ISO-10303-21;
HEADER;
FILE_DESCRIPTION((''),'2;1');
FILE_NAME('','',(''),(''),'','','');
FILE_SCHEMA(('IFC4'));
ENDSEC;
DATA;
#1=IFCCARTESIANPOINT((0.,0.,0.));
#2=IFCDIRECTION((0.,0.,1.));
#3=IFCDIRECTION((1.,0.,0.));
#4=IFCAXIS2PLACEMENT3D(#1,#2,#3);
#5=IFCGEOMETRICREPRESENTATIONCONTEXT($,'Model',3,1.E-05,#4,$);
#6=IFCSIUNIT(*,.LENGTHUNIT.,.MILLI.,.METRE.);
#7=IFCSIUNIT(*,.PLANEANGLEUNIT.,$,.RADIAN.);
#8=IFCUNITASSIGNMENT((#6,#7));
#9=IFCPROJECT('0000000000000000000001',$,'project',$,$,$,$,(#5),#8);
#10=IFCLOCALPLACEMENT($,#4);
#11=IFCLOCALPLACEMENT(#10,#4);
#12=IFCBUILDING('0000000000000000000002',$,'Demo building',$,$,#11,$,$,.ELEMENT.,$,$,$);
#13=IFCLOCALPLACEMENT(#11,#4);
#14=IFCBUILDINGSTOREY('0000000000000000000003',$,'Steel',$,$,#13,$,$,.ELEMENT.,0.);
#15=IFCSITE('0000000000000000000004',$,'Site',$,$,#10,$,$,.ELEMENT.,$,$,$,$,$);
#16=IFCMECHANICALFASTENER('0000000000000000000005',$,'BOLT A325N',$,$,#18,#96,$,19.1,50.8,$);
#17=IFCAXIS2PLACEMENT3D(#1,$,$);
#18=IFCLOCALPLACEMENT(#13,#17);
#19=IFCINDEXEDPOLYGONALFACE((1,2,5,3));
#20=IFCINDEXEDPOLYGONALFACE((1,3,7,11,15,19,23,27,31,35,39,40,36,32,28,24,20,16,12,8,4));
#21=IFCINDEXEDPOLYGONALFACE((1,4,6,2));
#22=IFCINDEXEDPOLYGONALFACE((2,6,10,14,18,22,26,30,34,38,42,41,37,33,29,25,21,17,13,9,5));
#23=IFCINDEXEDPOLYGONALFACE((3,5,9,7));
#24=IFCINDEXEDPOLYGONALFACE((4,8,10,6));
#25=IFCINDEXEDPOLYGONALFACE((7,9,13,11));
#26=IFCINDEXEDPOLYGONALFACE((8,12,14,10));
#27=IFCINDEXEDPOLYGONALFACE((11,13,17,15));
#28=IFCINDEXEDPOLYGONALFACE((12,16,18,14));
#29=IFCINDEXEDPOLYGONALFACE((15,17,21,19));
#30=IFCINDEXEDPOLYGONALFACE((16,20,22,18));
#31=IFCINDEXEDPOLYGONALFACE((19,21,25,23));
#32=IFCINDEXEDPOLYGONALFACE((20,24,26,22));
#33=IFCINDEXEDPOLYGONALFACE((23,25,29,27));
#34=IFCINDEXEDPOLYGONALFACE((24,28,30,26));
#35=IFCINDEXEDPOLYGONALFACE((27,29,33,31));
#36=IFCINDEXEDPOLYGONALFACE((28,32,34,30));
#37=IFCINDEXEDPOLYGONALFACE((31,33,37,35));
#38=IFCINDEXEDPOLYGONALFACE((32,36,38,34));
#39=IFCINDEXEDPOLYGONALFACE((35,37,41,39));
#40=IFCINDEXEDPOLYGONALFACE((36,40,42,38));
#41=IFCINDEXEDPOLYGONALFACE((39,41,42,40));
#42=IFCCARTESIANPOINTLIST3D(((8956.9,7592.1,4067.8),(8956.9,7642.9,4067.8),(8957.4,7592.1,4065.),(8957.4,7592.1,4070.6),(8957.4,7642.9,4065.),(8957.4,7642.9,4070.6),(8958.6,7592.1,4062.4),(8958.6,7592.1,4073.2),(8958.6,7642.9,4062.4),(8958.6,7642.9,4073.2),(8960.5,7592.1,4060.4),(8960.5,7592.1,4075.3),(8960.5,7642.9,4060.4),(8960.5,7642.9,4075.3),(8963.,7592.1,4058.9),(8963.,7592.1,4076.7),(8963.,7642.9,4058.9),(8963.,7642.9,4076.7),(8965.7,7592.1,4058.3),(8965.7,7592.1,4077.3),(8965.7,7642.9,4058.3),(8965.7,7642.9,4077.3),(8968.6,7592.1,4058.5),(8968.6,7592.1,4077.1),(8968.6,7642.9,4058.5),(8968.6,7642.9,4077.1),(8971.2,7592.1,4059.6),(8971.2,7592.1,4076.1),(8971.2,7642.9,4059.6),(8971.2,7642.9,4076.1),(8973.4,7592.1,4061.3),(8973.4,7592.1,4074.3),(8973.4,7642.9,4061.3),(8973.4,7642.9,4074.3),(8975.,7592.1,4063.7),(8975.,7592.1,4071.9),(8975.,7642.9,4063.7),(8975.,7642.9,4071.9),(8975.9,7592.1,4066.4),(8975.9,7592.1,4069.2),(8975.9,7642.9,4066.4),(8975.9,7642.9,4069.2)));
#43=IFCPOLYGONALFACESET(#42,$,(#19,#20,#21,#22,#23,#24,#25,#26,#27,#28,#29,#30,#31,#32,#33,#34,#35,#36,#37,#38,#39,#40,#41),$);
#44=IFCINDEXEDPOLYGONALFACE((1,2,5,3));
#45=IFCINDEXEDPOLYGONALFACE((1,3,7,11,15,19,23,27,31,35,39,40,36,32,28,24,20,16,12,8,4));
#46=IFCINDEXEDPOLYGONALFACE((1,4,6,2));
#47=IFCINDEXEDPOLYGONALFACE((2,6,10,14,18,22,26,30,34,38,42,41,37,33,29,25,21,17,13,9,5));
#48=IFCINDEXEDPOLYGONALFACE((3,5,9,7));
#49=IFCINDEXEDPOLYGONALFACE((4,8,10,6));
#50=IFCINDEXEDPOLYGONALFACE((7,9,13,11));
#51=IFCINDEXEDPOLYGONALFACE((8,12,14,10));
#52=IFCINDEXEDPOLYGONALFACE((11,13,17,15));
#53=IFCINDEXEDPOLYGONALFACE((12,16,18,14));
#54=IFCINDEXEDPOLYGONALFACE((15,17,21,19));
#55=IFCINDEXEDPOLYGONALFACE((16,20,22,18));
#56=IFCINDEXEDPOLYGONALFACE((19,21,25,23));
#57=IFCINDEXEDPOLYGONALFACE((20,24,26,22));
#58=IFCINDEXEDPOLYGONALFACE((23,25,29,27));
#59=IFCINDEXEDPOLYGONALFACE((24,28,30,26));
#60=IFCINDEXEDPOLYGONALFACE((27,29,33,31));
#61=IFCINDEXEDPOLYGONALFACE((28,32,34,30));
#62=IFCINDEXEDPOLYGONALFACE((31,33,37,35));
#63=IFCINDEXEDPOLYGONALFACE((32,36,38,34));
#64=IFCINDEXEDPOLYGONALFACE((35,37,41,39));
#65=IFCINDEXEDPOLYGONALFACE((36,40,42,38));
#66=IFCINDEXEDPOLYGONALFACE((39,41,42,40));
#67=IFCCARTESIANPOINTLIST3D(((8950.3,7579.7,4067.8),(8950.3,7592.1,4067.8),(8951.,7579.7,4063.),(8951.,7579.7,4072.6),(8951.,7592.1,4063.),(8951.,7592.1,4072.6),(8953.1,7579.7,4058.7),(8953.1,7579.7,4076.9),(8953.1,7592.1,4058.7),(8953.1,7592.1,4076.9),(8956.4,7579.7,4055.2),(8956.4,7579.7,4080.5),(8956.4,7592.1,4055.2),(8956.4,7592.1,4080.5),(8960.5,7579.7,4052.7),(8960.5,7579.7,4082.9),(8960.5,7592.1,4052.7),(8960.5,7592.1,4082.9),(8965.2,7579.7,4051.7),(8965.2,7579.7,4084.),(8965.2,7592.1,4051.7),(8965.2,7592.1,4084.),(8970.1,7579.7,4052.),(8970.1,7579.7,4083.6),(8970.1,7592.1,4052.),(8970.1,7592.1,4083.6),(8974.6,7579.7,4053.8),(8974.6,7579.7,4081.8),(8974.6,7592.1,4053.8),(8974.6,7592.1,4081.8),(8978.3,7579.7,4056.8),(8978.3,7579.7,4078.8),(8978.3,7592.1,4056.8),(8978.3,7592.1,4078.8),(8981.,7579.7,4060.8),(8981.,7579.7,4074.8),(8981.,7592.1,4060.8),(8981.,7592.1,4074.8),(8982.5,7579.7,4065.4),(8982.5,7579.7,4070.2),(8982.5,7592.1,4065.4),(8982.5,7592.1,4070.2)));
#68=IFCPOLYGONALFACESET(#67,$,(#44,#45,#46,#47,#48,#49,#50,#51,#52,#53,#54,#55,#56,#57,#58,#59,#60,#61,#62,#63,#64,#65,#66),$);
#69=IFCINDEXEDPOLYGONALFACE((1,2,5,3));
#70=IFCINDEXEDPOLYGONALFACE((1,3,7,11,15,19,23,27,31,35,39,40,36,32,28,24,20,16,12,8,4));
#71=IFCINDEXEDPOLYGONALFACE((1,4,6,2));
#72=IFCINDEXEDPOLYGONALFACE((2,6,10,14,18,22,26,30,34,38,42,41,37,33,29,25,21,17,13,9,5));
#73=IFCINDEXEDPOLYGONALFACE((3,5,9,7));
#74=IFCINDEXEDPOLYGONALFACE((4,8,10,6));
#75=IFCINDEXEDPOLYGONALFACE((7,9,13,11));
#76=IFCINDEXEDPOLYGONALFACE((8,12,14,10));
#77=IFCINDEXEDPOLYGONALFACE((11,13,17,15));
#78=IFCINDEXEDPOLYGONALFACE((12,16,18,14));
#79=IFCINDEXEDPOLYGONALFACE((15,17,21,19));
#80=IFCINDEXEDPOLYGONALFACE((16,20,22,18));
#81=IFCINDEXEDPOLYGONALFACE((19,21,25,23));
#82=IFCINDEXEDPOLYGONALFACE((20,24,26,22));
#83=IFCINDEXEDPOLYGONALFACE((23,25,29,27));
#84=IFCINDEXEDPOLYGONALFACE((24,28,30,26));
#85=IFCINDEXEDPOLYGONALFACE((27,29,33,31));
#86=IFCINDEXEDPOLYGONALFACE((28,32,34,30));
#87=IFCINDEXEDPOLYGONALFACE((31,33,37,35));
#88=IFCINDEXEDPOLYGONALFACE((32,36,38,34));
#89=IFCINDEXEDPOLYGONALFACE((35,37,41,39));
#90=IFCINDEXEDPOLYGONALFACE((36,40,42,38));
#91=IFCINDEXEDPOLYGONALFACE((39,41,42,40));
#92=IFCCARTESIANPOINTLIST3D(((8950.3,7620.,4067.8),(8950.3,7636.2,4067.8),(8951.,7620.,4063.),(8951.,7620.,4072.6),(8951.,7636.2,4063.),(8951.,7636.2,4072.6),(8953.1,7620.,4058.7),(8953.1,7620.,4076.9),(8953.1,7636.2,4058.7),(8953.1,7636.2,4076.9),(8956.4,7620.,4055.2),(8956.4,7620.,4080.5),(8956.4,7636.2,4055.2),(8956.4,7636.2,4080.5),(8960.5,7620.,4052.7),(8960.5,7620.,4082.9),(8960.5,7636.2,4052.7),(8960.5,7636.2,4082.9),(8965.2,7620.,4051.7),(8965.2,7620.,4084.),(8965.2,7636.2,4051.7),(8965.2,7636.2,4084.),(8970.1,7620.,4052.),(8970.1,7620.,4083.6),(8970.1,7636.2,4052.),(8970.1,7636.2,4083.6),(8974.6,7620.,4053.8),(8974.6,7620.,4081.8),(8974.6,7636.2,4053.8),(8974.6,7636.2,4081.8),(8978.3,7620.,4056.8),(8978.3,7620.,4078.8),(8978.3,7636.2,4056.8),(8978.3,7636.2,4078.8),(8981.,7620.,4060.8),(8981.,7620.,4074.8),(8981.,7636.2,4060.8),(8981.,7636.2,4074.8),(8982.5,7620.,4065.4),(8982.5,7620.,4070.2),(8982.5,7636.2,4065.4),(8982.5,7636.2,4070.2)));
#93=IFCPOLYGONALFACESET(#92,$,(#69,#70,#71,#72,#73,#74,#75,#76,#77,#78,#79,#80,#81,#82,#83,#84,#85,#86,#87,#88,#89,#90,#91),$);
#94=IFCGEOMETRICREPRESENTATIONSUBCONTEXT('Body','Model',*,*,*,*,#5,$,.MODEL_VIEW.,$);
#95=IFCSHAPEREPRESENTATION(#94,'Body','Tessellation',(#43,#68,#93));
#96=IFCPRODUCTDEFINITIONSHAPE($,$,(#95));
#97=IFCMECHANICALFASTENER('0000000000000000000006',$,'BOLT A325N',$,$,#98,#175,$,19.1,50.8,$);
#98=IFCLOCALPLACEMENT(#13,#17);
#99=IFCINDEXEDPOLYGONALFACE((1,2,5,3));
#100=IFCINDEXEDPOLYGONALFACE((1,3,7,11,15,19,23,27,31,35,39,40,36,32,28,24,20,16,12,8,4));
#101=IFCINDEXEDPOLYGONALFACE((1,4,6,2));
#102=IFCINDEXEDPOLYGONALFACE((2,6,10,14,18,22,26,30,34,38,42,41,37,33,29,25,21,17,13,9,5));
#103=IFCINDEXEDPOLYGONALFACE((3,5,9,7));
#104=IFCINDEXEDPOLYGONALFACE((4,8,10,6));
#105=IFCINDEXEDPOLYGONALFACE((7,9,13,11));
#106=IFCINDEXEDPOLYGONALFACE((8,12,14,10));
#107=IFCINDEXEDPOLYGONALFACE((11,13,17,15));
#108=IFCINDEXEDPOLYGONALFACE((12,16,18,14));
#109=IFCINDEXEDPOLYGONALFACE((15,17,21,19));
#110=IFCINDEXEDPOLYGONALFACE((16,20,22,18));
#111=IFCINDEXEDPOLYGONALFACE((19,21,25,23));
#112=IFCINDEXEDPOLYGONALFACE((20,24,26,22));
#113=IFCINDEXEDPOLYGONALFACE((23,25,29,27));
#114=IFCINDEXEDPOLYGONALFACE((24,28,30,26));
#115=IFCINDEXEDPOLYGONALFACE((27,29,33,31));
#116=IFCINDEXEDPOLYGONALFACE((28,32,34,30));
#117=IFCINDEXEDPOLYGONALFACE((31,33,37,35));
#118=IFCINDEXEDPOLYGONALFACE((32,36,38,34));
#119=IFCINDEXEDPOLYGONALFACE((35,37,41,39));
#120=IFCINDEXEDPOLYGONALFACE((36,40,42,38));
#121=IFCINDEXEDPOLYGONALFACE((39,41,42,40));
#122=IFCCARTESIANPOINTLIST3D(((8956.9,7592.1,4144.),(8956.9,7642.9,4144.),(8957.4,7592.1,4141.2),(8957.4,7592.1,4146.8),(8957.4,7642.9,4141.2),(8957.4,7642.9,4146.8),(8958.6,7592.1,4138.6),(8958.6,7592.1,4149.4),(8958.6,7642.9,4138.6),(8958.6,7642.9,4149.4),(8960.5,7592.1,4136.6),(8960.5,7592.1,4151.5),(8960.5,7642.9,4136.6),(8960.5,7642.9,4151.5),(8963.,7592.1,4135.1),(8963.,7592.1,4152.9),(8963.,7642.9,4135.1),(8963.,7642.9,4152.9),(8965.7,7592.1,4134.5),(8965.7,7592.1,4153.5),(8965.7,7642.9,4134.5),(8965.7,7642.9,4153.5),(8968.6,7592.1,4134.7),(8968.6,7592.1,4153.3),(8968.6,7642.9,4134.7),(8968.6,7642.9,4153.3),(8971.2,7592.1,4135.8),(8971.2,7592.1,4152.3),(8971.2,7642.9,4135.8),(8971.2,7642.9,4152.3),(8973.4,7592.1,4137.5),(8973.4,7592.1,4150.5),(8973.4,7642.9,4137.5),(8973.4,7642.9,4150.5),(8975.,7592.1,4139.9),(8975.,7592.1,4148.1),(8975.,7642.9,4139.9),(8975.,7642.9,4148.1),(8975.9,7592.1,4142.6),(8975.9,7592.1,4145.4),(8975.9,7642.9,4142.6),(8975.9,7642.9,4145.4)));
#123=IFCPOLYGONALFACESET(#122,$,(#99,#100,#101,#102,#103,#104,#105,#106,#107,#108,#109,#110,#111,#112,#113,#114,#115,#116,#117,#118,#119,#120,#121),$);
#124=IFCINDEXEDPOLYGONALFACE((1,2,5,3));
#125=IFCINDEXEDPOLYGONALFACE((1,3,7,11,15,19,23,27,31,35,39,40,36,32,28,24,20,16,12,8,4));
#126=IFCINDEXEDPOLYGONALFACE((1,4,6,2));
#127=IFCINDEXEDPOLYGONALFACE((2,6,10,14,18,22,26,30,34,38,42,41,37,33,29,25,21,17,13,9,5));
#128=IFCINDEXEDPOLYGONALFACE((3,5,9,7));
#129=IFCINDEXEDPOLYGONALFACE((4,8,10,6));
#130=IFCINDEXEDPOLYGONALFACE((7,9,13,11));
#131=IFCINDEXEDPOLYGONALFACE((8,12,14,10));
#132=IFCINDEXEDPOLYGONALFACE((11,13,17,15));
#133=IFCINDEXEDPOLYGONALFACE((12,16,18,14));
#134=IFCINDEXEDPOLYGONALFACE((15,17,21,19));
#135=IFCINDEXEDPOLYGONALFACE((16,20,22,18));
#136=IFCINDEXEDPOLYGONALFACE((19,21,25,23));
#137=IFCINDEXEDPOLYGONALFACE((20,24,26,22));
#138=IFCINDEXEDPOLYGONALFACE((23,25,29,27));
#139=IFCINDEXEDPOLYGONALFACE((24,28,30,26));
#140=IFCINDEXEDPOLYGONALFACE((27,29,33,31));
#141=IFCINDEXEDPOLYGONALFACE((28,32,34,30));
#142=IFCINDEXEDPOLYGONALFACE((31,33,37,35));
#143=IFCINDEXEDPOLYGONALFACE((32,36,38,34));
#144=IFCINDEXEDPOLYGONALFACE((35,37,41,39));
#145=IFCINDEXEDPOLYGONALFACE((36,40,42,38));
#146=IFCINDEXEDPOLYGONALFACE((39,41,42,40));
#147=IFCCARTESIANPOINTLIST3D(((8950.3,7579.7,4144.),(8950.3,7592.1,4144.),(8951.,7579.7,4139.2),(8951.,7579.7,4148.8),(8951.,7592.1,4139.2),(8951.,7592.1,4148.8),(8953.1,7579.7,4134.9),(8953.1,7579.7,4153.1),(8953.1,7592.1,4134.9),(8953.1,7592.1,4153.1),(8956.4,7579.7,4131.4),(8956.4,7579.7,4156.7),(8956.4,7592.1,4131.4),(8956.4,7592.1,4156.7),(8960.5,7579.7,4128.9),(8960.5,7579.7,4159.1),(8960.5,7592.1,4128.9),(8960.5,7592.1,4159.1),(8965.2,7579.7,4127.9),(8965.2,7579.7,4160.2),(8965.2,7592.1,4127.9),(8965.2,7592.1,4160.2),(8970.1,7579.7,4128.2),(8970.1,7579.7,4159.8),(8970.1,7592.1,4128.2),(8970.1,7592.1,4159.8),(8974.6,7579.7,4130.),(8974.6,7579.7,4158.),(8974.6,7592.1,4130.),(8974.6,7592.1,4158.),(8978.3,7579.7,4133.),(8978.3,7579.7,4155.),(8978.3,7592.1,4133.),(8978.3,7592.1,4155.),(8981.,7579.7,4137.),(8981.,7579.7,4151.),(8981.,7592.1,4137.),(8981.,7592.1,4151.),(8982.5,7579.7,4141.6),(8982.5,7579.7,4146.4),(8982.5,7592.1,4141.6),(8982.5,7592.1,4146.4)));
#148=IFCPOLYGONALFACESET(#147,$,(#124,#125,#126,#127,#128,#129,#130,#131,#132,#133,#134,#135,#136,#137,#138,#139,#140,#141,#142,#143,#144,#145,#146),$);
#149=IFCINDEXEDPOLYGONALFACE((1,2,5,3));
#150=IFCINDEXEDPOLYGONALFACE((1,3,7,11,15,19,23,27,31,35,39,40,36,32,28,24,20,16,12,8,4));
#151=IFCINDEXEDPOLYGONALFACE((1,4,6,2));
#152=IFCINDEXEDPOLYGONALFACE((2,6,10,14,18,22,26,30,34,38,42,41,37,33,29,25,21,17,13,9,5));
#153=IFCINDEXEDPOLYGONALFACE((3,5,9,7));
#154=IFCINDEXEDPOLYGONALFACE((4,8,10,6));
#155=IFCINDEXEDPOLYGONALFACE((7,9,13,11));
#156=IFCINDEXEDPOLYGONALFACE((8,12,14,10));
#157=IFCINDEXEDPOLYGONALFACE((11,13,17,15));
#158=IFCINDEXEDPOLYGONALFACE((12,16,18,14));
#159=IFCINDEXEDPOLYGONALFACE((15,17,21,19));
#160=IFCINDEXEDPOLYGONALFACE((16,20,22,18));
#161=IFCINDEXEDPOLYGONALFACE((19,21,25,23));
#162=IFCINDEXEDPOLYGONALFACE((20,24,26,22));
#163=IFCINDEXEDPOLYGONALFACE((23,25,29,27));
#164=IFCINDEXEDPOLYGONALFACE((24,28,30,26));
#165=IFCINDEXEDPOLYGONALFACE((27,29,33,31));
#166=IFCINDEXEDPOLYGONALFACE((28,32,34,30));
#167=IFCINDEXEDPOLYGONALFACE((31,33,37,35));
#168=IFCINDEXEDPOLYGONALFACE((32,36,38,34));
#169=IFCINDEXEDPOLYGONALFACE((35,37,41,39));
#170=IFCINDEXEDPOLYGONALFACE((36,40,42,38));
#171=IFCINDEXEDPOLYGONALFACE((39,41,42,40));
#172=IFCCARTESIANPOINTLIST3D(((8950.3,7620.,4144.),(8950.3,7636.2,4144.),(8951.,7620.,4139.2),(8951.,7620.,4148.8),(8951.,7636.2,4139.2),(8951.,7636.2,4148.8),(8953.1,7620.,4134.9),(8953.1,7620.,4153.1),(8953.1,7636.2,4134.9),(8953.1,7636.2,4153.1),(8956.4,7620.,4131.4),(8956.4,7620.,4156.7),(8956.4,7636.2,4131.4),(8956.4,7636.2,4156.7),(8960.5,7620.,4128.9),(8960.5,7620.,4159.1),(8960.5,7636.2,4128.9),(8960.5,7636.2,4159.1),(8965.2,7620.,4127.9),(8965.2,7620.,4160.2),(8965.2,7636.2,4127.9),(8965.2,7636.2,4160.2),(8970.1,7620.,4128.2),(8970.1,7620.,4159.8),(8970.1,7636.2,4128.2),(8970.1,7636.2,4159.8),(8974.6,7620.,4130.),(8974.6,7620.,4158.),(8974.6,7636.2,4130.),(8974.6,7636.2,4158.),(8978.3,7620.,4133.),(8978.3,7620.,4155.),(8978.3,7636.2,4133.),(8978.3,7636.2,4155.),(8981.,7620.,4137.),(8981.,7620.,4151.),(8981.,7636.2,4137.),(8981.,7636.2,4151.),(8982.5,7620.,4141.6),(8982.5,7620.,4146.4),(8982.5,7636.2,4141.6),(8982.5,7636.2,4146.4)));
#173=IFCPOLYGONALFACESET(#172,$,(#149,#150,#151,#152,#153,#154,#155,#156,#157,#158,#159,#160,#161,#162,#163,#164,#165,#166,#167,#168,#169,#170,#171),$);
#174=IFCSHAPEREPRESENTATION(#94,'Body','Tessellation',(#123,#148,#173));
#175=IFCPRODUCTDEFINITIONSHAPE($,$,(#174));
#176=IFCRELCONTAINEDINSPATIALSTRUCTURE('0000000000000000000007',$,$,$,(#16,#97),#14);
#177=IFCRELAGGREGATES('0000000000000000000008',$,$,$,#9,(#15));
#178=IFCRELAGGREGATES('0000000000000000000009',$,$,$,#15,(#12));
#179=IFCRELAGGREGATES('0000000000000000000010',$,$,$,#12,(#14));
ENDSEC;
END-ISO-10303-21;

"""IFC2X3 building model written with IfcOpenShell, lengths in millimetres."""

from ifc_helpers import new_model, si_unit, frame, origin, origin_with_axes, origin_2d, place, context, subcontext, project, spatial, circle, extrude, element, save


model = new_model("IFC2X3")

# Units and contexts
model_context = context("Model", 3, precision=1e-05, world=origin_with_axes())
body_context = subcontext(model_context, "Body", "Model", "MODEL_VIEW")
ifc_project = project(units=[si_unit("LENGTHUNIT", "METRE", prefix="MILLI"), si_unit("PLANEANGLEUNIT", "RADIAN")], contexts=[model_context])

# Site, building, storey
site_placement = place(None, origin_with_axes())
site = spatial("IfcSite", under=ifc_project, at=site_placement, Name="Site", CompositionType="ELEMENT")
building_placement = place(site_placement, origin_with_axes())
building = spatial("IfcBuilding", under=site, at=building_placement, Name="Demo building", CompositionType="ELEMENT")
placement = place(building_placement, origin_with_axes())
storey = spatial("IfcBuildingStorey", under=building, at=placement, Name="Steel", CompositionType="ELEMENT", Elevation=0.0)

# Mechanical fasteners
for number, where, z_axis, x_axis, name in (
    (1, (8966.5, 7592.1, 4067.8), (0.0, 1.0, 0.0), (-1.0, 0.0, 0.0), "BOLT A325N"),
    (2, (8966.5, 7592.1, 4144.0), (0.0, 1.0, 0.0), (-1.0, 0.0, 0.0), "BOLT A325N"),
):
    element("IfcMechanicalFastener", number, at=place(placement, frame(where, z_axis=z_axis, x_axis=x_axis)), inside=storey, Name=name, NominalDiameter=19.1, NominalLength=50.8, context=body_context, shape_type="SweptSolid", body=[
        extrude(circle(Radius=9.5, at=origin_2d()), origin(), (0.0, 0.0, 1.0), 50.8),
        extrude(circle(Radius=16.2, at=origin_2d()), frame((0.0, 0.0, -12.4)), (0.0, 0.0, 1.0), 12.4),
        extrude(circle(Radius=16.2, at=origin_2d()), frame((0.0, 0.0, 27.9)), (0.0, 0.0, 1.0), 16.2),
    ])

save(model, "model.ifc")
